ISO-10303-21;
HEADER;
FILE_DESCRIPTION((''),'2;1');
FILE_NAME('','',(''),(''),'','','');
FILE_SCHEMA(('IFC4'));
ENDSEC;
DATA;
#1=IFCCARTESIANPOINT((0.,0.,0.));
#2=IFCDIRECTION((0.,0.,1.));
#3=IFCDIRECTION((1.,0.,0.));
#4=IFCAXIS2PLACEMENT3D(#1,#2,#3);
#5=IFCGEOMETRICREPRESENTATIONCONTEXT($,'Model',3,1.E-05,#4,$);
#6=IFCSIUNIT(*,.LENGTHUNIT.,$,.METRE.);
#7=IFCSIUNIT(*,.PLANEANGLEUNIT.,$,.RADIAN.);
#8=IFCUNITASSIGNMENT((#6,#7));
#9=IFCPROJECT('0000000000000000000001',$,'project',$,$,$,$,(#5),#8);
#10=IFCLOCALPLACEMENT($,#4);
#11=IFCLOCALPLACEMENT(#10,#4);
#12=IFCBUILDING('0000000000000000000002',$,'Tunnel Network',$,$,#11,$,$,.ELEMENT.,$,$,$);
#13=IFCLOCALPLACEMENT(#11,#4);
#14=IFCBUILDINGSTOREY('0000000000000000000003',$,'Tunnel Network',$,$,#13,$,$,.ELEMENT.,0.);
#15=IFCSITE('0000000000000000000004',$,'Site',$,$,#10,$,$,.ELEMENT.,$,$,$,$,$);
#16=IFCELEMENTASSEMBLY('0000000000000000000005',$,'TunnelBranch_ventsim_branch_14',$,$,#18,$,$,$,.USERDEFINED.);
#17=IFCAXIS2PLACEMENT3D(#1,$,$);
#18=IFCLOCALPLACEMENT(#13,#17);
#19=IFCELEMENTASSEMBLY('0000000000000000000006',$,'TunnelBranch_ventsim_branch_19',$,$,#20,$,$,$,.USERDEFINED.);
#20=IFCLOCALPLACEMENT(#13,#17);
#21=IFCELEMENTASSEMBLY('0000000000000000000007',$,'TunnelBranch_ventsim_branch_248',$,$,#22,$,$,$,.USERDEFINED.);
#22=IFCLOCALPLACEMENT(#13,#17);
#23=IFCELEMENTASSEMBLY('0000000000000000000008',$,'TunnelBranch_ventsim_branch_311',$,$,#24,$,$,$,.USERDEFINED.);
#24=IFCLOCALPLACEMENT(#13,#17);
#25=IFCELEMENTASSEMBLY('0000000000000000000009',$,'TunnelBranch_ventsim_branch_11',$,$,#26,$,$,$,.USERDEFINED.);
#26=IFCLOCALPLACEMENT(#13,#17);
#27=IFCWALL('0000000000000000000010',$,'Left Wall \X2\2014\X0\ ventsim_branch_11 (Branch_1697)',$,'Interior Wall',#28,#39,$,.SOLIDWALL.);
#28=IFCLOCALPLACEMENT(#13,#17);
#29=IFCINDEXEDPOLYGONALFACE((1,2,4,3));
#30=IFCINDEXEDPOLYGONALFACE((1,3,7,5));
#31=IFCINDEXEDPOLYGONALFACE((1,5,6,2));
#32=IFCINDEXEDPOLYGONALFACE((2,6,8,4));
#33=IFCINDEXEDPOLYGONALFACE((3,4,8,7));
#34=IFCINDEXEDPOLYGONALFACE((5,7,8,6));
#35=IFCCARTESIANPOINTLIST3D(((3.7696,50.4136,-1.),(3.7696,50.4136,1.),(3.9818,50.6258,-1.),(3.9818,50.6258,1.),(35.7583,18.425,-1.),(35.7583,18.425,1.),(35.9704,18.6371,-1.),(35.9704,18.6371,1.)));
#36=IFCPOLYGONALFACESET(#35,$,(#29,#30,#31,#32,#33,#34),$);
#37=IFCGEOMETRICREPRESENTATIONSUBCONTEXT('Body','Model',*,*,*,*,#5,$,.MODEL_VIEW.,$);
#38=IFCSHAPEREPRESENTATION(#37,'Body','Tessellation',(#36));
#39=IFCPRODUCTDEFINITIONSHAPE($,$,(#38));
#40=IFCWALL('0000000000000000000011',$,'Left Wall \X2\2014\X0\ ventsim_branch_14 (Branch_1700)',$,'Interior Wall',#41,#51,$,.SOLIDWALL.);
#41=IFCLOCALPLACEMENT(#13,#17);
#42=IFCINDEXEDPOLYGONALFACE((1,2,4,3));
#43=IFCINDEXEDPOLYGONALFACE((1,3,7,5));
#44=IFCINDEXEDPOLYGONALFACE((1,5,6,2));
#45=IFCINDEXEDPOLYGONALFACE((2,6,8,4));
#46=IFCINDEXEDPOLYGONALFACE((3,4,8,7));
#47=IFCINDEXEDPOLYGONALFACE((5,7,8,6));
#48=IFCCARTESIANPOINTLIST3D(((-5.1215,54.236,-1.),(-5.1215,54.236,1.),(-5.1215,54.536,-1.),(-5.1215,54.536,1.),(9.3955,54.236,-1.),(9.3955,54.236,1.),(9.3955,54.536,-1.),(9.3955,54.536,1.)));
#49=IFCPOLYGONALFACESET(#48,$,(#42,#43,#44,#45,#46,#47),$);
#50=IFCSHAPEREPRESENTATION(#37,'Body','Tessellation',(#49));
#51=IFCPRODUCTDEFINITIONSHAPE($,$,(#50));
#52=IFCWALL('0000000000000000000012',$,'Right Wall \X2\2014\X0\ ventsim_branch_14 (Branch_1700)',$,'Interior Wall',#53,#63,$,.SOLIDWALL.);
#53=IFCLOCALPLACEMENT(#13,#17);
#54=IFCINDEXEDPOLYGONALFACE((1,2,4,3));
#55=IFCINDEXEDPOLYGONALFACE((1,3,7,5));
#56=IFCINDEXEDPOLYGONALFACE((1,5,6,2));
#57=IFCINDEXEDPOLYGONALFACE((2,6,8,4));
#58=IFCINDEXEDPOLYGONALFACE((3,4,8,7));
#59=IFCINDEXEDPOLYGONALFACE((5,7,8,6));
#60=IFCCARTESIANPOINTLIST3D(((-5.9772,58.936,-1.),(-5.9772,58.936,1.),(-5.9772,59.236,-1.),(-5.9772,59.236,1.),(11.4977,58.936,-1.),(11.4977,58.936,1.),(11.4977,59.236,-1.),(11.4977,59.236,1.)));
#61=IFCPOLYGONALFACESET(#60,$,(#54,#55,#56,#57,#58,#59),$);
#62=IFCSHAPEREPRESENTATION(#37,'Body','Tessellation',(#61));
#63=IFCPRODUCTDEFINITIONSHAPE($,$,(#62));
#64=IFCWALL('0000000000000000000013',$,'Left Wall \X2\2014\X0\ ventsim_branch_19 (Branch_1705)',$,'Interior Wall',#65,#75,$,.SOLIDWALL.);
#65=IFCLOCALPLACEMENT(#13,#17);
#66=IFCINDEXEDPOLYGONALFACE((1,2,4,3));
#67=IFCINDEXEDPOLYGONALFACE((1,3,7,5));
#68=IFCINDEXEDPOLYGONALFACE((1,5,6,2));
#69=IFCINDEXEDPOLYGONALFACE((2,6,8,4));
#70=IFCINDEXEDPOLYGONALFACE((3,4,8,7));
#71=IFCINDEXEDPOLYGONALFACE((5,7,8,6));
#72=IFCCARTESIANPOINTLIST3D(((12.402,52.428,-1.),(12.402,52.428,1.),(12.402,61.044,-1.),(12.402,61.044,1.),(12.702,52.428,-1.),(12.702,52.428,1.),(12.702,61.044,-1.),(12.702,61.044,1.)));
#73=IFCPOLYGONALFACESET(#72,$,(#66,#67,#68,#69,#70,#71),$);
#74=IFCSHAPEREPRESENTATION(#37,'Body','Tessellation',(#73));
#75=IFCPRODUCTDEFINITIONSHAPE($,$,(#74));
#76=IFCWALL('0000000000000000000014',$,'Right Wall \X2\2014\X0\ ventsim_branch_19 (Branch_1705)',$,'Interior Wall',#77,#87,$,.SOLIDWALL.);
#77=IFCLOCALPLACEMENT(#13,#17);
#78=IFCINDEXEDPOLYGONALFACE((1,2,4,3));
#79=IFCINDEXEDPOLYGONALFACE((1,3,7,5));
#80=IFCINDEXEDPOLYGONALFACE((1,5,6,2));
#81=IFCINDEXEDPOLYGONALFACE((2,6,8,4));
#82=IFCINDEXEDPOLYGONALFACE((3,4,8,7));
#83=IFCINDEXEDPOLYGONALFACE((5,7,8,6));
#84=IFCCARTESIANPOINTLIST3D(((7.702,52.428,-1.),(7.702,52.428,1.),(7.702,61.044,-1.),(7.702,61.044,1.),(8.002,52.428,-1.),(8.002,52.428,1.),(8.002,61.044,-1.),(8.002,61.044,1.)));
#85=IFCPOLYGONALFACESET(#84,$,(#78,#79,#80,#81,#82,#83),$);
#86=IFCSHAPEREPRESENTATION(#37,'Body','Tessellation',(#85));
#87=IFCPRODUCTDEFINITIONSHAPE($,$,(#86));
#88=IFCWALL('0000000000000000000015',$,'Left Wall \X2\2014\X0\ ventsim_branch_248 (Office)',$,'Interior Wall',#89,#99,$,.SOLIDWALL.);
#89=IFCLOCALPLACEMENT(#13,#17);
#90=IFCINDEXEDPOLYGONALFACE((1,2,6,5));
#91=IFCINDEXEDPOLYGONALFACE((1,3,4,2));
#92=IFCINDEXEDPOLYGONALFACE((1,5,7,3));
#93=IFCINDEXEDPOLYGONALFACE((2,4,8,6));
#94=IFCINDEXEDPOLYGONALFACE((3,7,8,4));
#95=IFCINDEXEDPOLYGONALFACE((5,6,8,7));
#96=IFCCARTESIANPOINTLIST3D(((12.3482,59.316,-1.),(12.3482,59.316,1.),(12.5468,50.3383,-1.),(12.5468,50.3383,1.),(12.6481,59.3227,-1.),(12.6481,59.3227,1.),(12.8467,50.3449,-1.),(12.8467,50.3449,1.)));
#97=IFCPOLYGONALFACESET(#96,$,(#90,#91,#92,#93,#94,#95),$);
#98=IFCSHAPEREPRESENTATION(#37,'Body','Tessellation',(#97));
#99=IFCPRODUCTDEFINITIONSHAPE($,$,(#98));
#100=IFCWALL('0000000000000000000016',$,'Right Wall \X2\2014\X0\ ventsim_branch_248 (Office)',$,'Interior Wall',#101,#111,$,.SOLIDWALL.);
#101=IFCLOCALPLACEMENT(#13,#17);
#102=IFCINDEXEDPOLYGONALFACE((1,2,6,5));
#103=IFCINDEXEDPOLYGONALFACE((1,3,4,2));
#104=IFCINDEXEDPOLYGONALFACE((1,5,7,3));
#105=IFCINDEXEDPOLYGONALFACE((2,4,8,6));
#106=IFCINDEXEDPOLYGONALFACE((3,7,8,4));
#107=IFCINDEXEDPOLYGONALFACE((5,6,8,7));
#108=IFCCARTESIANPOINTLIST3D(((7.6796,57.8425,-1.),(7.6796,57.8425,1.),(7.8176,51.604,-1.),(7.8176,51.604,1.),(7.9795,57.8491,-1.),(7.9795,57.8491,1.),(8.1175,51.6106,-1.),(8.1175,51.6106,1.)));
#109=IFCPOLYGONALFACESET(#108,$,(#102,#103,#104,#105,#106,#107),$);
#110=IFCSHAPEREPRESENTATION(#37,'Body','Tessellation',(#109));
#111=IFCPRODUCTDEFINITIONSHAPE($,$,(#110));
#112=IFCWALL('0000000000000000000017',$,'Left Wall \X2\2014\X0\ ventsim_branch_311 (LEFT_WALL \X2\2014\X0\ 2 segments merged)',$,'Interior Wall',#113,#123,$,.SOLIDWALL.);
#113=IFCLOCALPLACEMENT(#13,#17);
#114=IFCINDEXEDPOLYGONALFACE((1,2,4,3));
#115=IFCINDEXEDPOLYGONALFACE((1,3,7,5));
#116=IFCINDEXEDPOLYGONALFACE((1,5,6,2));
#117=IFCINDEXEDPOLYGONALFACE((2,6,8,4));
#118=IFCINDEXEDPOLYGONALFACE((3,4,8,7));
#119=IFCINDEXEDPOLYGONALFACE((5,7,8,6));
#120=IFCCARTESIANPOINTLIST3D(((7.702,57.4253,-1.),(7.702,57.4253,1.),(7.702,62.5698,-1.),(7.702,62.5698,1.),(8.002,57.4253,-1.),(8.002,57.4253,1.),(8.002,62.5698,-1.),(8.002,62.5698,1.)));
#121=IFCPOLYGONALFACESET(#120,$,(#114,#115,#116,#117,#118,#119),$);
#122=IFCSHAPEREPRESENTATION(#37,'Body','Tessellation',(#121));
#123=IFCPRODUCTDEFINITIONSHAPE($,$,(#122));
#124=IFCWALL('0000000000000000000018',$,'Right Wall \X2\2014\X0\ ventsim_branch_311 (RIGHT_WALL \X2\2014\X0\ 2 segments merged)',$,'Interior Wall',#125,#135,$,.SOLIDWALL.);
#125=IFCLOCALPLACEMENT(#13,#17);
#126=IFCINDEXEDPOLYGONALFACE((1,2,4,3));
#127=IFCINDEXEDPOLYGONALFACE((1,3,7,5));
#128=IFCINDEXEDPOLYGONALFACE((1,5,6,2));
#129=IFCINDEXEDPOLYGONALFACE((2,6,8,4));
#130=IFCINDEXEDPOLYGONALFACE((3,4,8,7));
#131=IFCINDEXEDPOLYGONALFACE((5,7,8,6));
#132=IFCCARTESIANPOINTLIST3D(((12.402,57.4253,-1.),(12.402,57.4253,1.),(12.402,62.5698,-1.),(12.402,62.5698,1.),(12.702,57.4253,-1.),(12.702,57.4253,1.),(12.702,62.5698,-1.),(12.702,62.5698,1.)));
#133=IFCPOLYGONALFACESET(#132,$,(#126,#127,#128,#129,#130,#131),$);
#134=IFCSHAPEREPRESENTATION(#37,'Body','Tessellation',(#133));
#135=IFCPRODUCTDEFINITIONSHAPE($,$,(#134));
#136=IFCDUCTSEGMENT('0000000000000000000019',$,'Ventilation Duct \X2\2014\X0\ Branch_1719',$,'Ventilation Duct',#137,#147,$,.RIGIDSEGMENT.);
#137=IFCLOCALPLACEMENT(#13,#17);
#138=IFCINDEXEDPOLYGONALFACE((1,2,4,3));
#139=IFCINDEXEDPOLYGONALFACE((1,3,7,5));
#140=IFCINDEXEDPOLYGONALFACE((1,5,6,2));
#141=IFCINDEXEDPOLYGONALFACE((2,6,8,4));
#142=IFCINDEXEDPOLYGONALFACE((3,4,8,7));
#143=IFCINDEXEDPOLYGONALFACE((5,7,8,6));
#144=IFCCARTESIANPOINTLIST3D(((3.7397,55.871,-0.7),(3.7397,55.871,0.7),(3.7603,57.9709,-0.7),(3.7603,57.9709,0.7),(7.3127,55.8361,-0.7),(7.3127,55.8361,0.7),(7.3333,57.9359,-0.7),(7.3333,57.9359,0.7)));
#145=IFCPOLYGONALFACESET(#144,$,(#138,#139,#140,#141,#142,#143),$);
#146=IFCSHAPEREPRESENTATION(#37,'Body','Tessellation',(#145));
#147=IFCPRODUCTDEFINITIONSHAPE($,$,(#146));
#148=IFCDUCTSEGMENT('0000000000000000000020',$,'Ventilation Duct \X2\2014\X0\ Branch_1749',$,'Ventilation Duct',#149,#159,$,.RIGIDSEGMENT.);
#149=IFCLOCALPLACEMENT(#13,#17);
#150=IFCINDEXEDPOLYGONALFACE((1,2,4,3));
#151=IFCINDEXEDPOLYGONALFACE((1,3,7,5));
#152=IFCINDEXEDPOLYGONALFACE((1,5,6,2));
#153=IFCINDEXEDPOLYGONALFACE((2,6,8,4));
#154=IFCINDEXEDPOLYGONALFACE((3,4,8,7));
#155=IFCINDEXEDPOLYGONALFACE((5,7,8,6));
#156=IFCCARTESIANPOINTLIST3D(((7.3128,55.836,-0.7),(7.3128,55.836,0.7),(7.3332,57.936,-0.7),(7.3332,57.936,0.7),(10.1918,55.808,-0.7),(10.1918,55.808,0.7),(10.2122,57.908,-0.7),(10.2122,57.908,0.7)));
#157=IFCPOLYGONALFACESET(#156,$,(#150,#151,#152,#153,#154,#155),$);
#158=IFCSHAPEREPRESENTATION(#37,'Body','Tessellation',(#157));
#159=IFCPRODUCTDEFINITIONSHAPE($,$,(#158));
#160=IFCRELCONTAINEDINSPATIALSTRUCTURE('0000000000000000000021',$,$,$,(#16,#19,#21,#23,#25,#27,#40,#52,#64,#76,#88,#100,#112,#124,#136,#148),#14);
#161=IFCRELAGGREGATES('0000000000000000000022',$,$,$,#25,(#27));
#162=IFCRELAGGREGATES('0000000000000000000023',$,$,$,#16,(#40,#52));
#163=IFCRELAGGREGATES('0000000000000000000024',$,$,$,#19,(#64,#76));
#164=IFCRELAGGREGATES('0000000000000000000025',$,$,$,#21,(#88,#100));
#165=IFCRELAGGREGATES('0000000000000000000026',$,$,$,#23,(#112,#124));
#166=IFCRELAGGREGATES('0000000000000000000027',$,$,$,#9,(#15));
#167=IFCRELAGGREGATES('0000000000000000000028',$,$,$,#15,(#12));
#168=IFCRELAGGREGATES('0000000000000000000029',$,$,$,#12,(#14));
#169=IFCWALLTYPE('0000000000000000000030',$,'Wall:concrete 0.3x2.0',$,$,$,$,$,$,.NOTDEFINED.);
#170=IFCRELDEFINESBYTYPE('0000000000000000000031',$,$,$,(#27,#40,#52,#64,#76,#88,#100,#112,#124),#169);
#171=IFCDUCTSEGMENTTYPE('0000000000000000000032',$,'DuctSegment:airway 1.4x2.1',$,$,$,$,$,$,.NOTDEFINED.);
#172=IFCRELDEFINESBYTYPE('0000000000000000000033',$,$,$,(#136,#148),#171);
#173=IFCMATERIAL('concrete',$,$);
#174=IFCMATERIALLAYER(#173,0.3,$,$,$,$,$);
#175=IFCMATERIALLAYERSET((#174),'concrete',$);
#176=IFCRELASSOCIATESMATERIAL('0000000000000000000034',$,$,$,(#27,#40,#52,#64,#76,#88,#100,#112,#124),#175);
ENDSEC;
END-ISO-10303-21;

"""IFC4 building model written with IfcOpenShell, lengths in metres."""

from ifc_helpers import new_model, si_unit, frame, origin_with_axes, origin_2d_with_axis, place, context, subcontext, project, spatial, rectangle, extrude, material, layer, layer_set, layer_usage, type_object, element, aggregate, save


model = new_model("IFC4")

# Units and contexts
model_context = context("Model", 3, precision=1e-05, world=origin_with_axes())
body_context = subcontext(model_context, "Body", "Model", "MODEL_VIEW")
ifc_project = project(units=[si_unit("LENGTHUNIT", "METRE"), si_unit("PLANEANGLEUNIT", "RADIAN")], contexts=[model_context])

# Site, building, storey
site_placement = place(None, origin_with_axes())
site = spatial("IfcSite", under=ifc_project, at=site_placement, Name="Site", CompositionType="ELEMENT")
building_placement = place(site_placement, origin_with_axes())
building = spatial("IfcBuilding", under=site, at=building_placement, Name="Tunnel Network", CompositionType="ELEMENT")
storey_placement = place(building_placement, origin_with_axes())
storey = spatial("IfcBuildingStorey", under=building, at=storey_placement, Name="Tunnel Network", CompositionType="ELEMENT", Elevation=0.0)

# Element assemblies
assembly_1_placement = place(storey_placement, frame((9.3955, 54.386, 0.0), z_axis=(-1.0, 0.0, 0.0), x_axis=(0.0, 1.0, 0.0)))
assembly_1 = element("IfcElementAssembly", 1, at=assembly_1_placement, inside=storey, Name="TunnelBranch_ventsim_branch_14", PredefinedType="USERDEFINED")
ifc_material_1 = material(Name="concrete")
ifc_layer_1 = layer(ifc_material_1, 0.3)
ifc_layer_set_1 = layer_set([ifc_layer_1], Name="concrete")
assembly_2_placement = place(storey_placement, frame((12.552, 61.044, 0.0), z_axis=(0.0, -1.0, 0.0), x_axis=(-1.0, 0.0, 0.0)))
assembly_2 = element("IfcElementAssembly", 2, at=assembly_2_placement, inside=storey, Name="TunnelBranch_ventsim_branch_19", PredefinedType="USERDEFINED")
assembly_3_placement = place(storey_placement, frame((12.4981, 59.3193, 0.0), z_axis=(0.022115, -0.999755, 0.0), x_axis=(-0.999755, -0.022115, 0.0)))
assembly_3 = element("IfcElementAssembly", 3, at=assembly_3_placement, inside=storey, Name="TunnelBranch_ventsim_branch_248", PredefinedType="USERDEFINED")
assembly_4_placement = place(storey_placement, frame((10.202, 56.2907, 0.0), z_axis=(0.0, 1.0, 0.0), x_axis=(1.0, 0.0, 0.0)))
assembly_4 = element("IfcElementAssembly", 4, at=assembly_4_placement, inside=storey, Name="TunnelBranch_ventsim_branch_311", PredefinedType="USERDEFINED")

# Element assembly, wall
assembly_5_placement = place(storey_placement, frame((3.8757, 50.5197, 0.0), z_axis=(0.707107, -0.707107, 0.0), x_axis=(-0.707107, -0.707107, 0.0)))
assembly_5 = element("IfcElementAssembly", 5, at=assembly_5_placement, inside=storey, Name="TunnelBranch_ventsim_branch_11", PredefinedType="USERDEFINED")
ifc_layer_usage_1 = layer_usage(ifc_layer_set_1, "AXIS2", "POSITIVE", 0.0)
wall_type_1 = type_object("IfcWallType", Name="Wall:concrete 0.3x2.0")
wall_1_placement = place(storey_placement, frame((3.8757, 50.5197, 0.0), z_axis=(0.707107, -0.707107, 0.0), x_axis=(-0.707107, -0.707107, 0.0)))
wall_1 = element("IfcWall", 6, at=wall_1_placement, inside=storey, type_object=wall_type_1, material=ifc_layer_usage_1, Name="Left Wall — ventsim_branch_11 (Branch_1697)", ObjectType="Interior Wall", PredefinedType="SOLIDWALL", context=body_context, shape_type="SweptSolid", body=[
    extrude(rectangle(XDim=0.3, YDim=2.0, at=origin_2d_with_axis()), origin_with_axes(), (0.0, 0.0, 1.0), 45.2387),
])
aggregate(assembly_5, [wall_1])

# Walls
ifc_layer_usage_2 = layer_usage(ifc_layer_set_1, "AXIS2", "POSITIVE", 0.0)
wall_2_placement = place(storey_placement, frame((9.3955, 54.386, 0.0), z_axis=(-1.0, 0.0, 0.0), x_axis=(0.0, 1.0, 0.0)))
wall_2 = element("IfcWall", 7, at=wall_2_placement, inside=storey, type_object=wall_type_1, material=ifc_layer_usage_2, Name="Left Wall — ventsim_branch_14 (Branch_1700)", ObjectType="Interior Wall", PredefinedType="SOLIDWALL", context=body_context, shape_type="SweptSolid", body=[
    extrude(rectangle(XDim=0.3, YDim=2.0, at=origin_2d_with_axis()), origin_with_axes(), (0.0, 0.0, 1.0), 14.517),
])
ifc_layer_usage_3 = layer_usage(ifc_layer_set_1, "AXIS2", "POSITIVE", 0.0)
wall_3_placement = place(storey_placement, frame((11.4977, 59.086, 0.0), z_axis=(-1.0, 0.0, 0.0), x_axis=(0.0, 1.0, 0.0)))
wall_3 = element("IfcWall", 8, at=wall_3_placement, inside=storey, type_object=wall_type_1, material=ifc_layer_usage_3, Name="Right Wall — ventsim_branch_14 (Branch_1700)", ObjectType="Interior Wall", PredefinedType="SOLIDWALL", context=body_context, shape_type="SweptSolid", body=[
    extrude(rectangle(XDim=0.3, YDim=2.0, at=origin_2d_with_axis()), origin_with_axes(), (0.0, 0.0, 1.0), 17.4749),
])
aggregate(assembly_1, [wall_2, wall_3])
ifc_layer_usage_4 = layer_usage(ifc_layer_set_1, "AXIS2", "POSITIVE", 0.0)
wall_4_placement = place(storey_placement, frame((12.552, 61.044, 0.0), z_axis=(0.0, -1.0, 0.0), x_axis=(-1.0, 0.0, 0.0)))
wall_4 = element("IfcWall", 9, at=wall_4_placement, inside=storey, type_object=wall_type_1, material=ifc_layer_usage_4, Name="Left Wall — ventsim_branch_19 (Branch_1705)", ObjectType="Interior Wall", PredefinedType="SOLIDWALL", context=body_context, shape_type="SweptSolid", body=[
    extrude(rectangle(XDim=0.3, YDim=2.0, at=origin_2d_with_axis()), origin_with_axes(), (0.0, 0.0, 1.0), 8.616),
])
ifc_layer_usage_5 = layer_usage(ifc_layer_set_1, "AXIS2", "POSITIVE", 0.0)
wall_5_placement = place(storey_placement, frame((7.852, 61.044, 0.0), z_axis=(0.0, -1.0, 0.0), x_axis=(-1.0, 0.0, 0.0)))
wall_5 = element("IfcWall", 10, at=wall_5_placement, inside=storey, type_object=wall_type_1, material=ifc_layer_usage_5, Name="Right Wall — ventsim_branch_19 (Branch_1705)", ObjectType="Interior Wall", PredefinedType="SOLIDWALL", context=body_context, shape_type="SweptSolid", body=[
    extrude(rectangle(XDim=0.3, YDim=2.0, at=origin_2d_with_axis()), origin_with_axes(), (0.0, 0.0, 1.0), 8.616),
])
aggregate(assembly_2, [wall_4, wall_5])
ifc_layer_usage_6 = layer_usage(ifc_layer_set_1, "AXIS2", "POSITIVE", 0.0)
wall_6_placement = place(storey_placement, frame((12.4981, 59.3193, 0.0), z_axis=(0.022115, -0.999755, 0.0), x_axis=(-0.999755, -0.022115, 0.0)))
wall_6 = element("IfcWall", 11, at=wall_6_placement, inside=storey, type_object=wall_type_1, material=ifc_layer_usage_6, Name="Left Wall — ventsim_branch_248 (Office)", ObjectType="Interior Wall", PredefinedType="SOLIDWALL", context=body_context, shape_type="SweptSolid", body=[
    extrude(rectangle(XDim=0.3, YDim=2.0, at=origin_2d_with_axis()), origin_with_axes(), (0.0, 0.0, 1.0), 8.9799),
])
ifc_layer_usage_7 = layer_usage(ifc_layer_set_1, "AXIS2", "POSITIVE", 0.0)
wall_7_placement = place(storey_placement, frame((7.8296, 57.8458, 0.0), z_axis=(0.022115, -0.999755, 0.0), x_axis=(-0.999755, -0.022115, 0.0)))
wall_7 = element("IfcWall", 12, at=wall_7_placement, inside=storey, type_object=wall_type_1, material=ifc_layer_usage_7, Name="Right Wall — ventsim_branch_248 (Office)", ObjectType="Interior Wall", PredefinedType="SOLIDWALL", context=body_context, shape_type="SweptSolid", body=[
    extrude(rectangle(XDim=0.3, YDim=2.0, at=origin_2d_with_axis()), origin_with_axes(), (0.0, 0.0, 1.0), 6.24),
])
aggregate(assembly_3, [wall_6, wall_7])
ifc_layer_usage_8 = layer_usage(ifc_layer_set_1, "AXIS2", "POSITIVE", 0.0)
wall_8_placement = place(storey_placement, frame((7.852, 57.4253, 0.0), z_axis=(0.0, 1.0, 0.0), x_axis=(1.0, 0.0, 0.0)))
wall_8 = element("IfcWall", 13, at=wall_8_placement, inside=storey, type_object=wall_type_1, material=ifc_layer_usage_8, Name="Left Wall — ventsim_branch_311 (LEFT_WALL — 2 segments merged)", ObjectType="Interior Wall", PredefinedType="SOLIDWALL", context=body_context, shape_type="SweptSolid", body=[
    extrude(rectangle(XDim=0.3, YDim=2.0, at=origin_2d_with_axis()), origin_with_axes(), (0.0, 0.0, 1.0), 5.1445),
])
ifc_layer_usage_9 = layer_usage(ifc_layer_set_1, "AXIS2", "POSITIVE", 0.0)
wall_9_placement = place(storey_placement, frame((12.552, 57.4253, 0.0), z_axis=(0.0, 1.0, 0.0), x_axis=(1.0, 0.0, 0.0)))
wall_9 = element("IfcWall", 14, at=wall_9_placement, inside=storey, type_object=wall_type_1, material=ifc_layer_usage_9, Name="Right Wall — ventsim_branch_311 (RIGHT_WALL — 2 segments merged)", ObjectType="Interior Wall", PredefinedType="SOLIDWALL", context=body_context, shape_type="SweptSolid", body=[
    extrude(rectangle(XDim=0.3, YDim=2.0, at=origin_2d_with_axis()), origin_with_axes(), (0.0, 0.0, 1.0), 5.1445),
])
aggregate(assembly_4, [wall_8, wall_9])

# Duct segments
duct_segment_type_1 = type_object("IfcDuctSegmentType", Name="DuctSegment:airway 1.4x2.1")
duct_segment_1_placement = place(storey_placement, frame((3.75, 56.921, 0.0), z_axis=(0.999952, -0.009795, 0.0), x_axis=(0.0, 0.0, 1.0)))
element("IfcDuctSegment", 15, at=duct_segment_1_placement, inside=storey, type_object=duct_segment_type_1, Name="Ventilation Duct — Branch_1719", ObjectType="Ventilation Duct", PredefinedType="RIGIDSEGMENT", context=body_context, shape_type="SweptSolid", body=[
    extrude(rectangle(XDim=1.4, YDim=2.1, at=origin_2d_with_axis()), origin_with_axes(), (0.0, 0.0, 1.0), 3.5732),
])
duct_segment_2_placement = place(storey_placement, frame((7.323, 56.886, 0.0), z_axis=(0.999953, -0.009725, 0.0), x_axis=(0.0, 0.0, 1.0)))
element("IfcDuctSegment", 16, at=duct_segment_2_placement, inside=storey, type_object=duct_segment_type_1, Name="Ventilation Duct — Branch_1749", ObjectType="Ventilation Duct", PredefinedType="RIGIDSEGMENT", context=body_context, shape_type="SweptSolid", body=[
    extrude(rectangle(XDim=1.4, YDim=2.1, at=origin_2d_with_axis()), origin_with_axes(), (0.0, 0.0, 1.0), 2.8791),
])

save(model, "model.ifc")
